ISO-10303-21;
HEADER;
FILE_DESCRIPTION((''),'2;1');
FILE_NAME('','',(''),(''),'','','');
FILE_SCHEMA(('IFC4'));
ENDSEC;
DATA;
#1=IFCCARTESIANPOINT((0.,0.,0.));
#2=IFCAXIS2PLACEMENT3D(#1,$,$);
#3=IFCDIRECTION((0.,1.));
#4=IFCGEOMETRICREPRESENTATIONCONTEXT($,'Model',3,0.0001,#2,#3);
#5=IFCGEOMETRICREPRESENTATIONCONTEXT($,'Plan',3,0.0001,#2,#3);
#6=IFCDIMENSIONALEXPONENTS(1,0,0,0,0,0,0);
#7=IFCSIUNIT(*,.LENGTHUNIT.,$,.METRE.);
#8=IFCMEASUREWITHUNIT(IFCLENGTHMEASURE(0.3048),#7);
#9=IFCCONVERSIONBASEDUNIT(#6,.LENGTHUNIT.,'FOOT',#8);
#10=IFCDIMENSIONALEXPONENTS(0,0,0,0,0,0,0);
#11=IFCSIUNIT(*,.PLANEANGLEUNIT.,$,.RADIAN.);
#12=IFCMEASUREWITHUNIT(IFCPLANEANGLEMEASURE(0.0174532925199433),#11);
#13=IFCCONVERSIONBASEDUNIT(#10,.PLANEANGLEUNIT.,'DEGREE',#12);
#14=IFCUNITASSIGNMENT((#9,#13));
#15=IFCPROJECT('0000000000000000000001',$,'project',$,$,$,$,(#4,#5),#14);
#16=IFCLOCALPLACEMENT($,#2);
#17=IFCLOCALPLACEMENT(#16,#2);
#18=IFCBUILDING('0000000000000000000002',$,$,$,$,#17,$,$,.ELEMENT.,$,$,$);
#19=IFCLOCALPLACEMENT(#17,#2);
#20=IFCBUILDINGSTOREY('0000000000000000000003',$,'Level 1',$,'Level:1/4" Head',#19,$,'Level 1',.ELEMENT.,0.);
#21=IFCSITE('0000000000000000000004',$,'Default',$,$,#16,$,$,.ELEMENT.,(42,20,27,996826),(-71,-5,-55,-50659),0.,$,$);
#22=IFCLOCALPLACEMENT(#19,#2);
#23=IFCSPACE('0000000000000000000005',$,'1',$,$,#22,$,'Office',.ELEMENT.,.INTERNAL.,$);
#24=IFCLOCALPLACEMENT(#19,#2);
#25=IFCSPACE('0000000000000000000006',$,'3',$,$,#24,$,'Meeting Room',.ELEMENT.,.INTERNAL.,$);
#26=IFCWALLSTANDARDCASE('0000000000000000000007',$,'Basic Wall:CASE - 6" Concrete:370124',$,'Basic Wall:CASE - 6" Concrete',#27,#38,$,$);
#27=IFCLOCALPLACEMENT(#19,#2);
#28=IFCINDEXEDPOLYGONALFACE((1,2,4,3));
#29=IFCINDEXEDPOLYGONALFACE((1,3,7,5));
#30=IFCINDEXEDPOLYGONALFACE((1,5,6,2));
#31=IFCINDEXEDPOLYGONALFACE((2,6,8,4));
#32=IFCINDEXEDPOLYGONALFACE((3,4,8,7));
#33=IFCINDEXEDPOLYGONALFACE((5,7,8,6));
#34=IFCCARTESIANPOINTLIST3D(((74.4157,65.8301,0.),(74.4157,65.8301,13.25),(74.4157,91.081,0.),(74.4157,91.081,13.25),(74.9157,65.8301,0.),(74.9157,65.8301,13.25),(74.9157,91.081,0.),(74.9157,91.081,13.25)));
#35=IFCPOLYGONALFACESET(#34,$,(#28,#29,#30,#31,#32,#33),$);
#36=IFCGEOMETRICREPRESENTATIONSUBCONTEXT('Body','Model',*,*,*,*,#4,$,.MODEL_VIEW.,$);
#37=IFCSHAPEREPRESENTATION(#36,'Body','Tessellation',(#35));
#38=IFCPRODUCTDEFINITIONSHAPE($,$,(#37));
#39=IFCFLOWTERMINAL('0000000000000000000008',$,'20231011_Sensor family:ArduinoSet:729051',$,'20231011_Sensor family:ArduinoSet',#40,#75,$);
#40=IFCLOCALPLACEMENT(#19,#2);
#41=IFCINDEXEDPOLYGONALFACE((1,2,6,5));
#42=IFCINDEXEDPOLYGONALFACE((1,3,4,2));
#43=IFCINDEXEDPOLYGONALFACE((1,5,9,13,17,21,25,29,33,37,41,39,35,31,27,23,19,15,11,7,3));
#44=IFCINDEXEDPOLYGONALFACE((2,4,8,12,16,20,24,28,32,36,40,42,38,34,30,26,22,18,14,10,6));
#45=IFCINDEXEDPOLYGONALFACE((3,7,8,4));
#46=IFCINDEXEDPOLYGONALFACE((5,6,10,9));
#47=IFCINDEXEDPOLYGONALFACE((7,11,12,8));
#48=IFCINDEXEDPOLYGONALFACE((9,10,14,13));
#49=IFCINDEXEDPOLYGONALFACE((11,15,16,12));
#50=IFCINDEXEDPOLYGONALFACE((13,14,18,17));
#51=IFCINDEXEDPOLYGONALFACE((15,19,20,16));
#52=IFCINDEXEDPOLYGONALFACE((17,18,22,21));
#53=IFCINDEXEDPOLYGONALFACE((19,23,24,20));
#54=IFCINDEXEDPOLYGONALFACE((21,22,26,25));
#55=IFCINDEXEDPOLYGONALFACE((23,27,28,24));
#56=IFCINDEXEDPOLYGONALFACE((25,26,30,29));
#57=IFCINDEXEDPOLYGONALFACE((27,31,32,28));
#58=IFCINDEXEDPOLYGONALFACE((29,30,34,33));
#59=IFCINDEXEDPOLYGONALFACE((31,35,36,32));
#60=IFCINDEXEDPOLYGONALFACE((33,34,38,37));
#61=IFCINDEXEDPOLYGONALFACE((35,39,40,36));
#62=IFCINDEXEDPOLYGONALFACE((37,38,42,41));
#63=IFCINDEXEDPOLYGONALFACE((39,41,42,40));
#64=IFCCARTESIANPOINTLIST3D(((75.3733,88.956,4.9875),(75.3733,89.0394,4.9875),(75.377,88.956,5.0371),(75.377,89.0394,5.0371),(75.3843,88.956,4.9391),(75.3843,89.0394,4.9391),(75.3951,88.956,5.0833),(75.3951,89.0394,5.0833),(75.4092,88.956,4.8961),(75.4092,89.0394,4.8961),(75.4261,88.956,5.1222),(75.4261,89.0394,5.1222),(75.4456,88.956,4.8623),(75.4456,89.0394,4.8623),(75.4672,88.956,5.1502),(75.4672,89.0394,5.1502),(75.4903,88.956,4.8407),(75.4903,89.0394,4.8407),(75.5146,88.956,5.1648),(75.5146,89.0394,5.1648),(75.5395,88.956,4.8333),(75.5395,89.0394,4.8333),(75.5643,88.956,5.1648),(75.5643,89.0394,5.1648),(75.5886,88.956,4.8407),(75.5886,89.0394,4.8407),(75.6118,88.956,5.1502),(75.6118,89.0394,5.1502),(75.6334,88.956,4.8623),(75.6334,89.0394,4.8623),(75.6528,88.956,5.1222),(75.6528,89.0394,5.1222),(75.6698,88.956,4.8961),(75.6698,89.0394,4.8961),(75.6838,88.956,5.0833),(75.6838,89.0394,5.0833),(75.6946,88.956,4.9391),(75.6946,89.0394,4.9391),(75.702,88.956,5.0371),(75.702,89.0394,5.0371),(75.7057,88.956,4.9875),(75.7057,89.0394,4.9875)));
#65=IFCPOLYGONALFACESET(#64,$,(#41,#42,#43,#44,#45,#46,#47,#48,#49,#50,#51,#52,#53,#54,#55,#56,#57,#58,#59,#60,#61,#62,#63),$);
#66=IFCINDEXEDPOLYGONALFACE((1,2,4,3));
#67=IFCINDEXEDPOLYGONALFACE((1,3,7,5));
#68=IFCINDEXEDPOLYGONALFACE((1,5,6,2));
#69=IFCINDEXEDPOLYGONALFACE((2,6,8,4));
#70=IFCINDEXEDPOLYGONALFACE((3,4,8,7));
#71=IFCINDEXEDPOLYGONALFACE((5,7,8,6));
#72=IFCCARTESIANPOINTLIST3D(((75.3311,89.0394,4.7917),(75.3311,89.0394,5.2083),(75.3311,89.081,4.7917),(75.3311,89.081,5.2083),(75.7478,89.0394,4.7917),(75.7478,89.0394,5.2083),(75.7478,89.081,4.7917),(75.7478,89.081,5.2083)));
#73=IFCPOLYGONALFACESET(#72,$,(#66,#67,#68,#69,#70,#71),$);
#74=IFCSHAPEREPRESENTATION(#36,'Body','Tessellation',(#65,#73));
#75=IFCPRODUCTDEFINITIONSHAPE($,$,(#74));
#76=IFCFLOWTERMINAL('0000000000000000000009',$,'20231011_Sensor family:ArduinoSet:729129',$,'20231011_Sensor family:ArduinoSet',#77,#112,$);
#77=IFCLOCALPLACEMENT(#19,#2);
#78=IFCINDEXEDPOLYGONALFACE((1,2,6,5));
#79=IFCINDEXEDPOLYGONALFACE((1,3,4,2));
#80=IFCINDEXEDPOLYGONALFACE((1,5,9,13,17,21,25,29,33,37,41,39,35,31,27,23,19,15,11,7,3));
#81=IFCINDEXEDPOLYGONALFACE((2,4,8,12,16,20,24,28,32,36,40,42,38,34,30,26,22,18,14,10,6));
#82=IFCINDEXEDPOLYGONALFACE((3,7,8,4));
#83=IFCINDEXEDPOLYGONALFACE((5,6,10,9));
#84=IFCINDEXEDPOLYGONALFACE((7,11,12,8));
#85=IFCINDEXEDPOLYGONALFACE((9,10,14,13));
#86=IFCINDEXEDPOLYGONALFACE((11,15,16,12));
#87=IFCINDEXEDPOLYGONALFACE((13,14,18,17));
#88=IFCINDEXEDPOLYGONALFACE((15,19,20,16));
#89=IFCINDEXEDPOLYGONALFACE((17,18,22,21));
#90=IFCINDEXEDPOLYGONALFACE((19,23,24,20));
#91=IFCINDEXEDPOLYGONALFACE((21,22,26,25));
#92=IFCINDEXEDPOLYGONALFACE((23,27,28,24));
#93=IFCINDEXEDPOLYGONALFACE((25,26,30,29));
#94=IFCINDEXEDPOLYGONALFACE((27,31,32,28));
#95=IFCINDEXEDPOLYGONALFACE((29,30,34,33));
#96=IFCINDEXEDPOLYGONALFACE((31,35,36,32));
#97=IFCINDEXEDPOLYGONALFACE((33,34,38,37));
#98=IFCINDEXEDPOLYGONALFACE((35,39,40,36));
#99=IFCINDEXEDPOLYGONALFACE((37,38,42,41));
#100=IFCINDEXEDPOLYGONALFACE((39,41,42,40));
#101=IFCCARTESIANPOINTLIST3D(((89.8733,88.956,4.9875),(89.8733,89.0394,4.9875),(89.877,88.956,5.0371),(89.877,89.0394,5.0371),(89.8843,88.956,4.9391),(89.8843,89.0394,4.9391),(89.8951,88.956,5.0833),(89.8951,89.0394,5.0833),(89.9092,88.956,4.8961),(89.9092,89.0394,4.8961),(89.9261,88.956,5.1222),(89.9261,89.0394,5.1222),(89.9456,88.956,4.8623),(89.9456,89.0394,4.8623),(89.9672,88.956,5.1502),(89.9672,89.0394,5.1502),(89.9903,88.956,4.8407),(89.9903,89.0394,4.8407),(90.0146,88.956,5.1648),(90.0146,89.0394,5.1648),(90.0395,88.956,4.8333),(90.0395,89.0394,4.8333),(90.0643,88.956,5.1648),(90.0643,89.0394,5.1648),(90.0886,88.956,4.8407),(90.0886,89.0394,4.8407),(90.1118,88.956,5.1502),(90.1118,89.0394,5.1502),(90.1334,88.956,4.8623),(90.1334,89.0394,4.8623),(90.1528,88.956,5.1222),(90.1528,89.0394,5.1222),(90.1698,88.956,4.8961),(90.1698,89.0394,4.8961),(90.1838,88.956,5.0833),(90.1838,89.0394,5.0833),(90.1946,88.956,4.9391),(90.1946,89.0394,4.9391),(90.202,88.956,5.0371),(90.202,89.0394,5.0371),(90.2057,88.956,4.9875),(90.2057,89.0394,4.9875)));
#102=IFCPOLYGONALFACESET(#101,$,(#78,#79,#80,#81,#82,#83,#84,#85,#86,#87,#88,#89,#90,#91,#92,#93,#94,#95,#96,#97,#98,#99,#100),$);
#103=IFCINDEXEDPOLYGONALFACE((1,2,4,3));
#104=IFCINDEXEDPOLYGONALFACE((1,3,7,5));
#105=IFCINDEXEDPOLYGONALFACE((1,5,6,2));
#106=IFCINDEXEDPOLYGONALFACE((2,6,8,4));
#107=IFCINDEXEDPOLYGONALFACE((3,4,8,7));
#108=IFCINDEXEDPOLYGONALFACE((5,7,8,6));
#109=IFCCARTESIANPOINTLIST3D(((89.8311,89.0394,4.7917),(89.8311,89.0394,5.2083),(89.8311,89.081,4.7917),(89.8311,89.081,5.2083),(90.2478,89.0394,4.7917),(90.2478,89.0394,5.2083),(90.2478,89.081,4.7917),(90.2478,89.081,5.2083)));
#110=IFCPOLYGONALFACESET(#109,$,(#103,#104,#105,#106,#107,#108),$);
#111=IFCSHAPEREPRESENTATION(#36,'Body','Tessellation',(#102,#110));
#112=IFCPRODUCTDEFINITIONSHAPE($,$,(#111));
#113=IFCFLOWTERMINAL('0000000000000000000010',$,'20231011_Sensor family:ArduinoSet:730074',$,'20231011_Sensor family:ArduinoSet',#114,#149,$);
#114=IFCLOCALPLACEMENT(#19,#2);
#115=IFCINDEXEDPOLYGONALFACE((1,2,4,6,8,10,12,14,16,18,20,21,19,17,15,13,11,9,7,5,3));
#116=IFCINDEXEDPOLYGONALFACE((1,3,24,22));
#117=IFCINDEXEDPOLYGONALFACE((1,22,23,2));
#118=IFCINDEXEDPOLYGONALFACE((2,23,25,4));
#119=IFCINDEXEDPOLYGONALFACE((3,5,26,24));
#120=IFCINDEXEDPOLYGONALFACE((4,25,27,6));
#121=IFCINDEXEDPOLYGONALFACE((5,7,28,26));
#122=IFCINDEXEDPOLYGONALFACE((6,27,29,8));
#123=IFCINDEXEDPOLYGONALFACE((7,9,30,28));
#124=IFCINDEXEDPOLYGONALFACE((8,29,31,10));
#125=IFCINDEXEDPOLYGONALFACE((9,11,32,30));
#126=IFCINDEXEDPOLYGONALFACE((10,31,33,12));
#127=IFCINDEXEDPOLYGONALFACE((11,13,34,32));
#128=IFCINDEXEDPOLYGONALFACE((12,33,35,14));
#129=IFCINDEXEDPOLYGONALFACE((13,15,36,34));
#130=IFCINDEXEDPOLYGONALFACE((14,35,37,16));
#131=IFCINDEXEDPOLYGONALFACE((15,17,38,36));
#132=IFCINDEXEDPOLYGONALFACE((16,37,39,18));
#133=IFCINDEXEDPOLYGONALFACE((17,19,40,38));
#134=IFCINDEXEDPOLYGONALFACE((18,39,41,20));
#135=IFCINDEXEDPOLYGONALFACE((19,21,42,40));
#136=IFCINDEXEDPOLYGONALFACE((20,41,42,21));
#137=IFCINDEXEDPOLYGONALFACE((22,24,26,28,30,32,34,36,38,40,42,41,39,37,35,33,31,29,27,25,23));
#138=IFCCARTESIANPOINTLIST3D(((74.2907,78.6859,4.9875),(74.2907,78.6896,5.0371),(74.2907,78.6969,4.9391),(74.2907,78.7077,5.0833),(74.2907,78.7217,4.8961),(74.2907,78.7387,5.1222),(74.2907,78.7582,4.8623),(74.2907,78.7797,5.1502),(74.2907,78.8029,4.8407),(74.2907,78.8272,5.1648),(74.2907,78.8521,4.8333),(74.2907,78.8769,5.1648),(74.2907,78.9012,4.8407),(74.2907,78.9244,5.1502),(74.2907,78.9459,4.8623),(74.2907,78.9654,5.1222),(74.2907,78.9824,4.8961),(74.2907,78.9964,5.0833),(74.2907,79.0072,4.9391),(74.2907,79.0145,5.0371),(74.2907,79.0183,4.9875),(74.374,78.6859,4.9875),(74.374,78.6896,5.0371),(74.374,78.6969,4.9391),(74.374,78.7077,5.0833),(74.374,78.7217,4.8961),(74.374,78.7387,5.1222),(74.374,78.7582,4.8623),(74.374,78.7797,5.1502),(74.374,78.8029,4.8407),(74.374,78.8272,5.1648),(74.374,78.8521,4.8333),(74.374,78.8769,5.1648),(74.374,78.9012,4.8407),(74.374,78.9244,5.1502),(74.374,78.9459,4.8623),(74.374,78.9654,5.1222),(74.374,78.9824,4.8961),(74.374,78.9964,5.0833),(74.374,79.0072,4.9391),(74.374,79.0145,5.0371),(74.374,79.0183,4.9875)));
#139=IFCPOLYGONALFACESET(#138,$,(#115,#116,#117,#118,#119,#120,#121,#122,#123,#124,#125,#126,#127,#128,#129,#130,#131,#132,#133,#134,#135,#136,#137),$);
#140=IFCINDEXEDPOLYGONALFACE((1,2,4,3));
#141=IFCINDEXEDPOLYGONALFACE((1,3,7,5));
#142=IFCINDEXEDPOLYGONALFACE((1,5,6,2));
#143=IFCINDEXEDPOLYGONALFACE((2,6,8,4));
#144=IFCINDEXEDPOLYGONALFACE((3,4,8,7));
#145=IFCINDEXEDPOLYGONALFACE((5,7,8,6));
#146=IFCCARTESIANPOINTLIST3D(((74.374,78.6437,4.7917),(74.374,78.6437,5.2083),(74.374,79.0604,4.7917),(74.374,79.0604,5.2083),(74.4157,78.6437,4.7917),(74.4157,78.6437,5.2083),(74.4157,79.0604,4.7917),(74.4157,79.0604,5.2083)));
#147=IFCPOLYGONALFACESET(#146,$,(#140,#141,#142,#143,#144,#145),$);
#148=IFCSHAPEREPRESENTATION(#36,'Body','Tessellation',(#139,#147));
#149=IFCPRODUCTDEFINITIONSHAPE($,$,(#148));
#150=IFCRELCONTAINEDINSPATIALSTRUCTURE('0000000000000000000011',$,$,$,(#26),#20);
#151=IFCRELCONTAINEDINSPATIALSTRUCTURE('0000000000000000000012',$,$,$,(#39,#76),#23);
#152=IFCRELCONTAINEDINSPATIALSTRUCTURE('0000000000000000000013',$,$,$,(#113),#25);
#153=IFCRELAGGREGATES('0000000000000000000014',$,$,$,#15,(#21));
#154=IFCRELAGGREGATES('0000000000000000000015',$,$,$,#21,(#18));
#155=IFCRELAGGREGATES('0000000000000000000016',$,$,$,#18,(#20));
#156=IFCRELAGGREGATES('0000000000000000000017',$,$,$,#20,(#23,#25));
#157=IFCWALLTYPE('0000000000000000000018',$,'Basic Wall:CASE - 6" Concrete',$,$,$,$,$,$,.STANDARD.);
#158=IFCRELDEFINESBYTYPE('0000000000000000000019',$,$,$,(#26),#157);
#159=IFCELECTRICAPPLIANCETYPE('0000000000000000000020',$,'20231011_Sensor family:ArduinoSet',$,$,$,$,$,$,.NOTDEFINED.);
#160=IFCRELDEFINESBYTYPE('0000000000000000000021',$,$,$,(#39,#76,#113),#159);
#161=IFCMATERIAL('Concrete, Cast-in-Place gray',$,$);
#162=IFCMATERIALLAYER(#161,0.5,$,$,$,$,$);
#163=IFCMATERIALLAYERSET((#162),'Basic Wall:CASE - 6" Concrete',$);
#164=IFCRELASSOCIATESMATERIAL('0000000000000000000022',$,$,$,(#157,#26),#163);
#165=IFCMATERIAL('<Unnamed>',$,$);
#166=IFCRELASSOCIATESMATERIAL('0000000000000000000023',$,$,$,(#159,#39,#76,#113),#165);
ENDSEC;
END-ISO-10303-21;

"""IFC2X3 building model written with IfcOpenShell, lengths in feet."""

from ifc_helpers import new_model, entity, si_unit, converted_unit, direction, frame, frame_2d, origin, origin_2d_with_axis, place, context, subcontext, project, spatial, rectangle, circle, extrude, source, transform, mapped, material, layer, layer_set, layer_usage, type_object, type_shapes, element, save


model = new_model("IFC2X3")

# Units and contexts
model_context = context("Model", 3, precision=0.0001, world=origin(), true_north=direction((0.0, 1.0)))
plan_context = context("Plan", 3, precision=0.0001, world=origin(), true_north=direction((0.0, 1.0)))
body_context = subcontext(model_context, "Body", "Model", "MODEL_VIEW")
ifc_project = project(units=[converted_unit("LENGTHUNIT", "FOOT", entity("IfcLengthMeasure", 0.3048), si_unit("LENGTHUNIT", "METRE"), dimensions=[1, 0, 0, 0, 0, 0, 0]), converted_unit("PLANEANGLEUNIT", "DEGREE", entity("IfcPlaneAngleMeasure", 0.0174532925199433), si_unit("PLANEANGLEUNIT", "RADIAN"), dimensions=[0, 0, 0, 0, 0, 0, 0])], contexts=[model_context, plan_context])

# Site, building, storey
site_placement = place(None, origin())
site = spatial("IfcSite", under=ifc_project, at=site_placement, Name="Default", CompositionType="ELEMENT", RefLatitude=(42, 20, 27, 996826), RefLongitude=(-71, -5, -55, -50659), RefElevation=0.0)
building_placement = place(site_placement, origin())
building = spatial("IfcBuilding", under=site, at=building_placement, CompositionType="ELEMENT")
storey_placement = place(building_placement, origin())
storey = spatial("IfcBuildingStorey", under=building, at=storey_placement, Name="Level 1", ObjectType="Level:1/4\" Head", LongName="Level 1", CompositionType="ELEMENT", Elevation=0.0)

# Wall
ifc_material_1 = material(Name="Concrete, Cast-in-Place gray")
ifc_layer = layer(ifc_material_1, 0.5)
ifc_layer_set = layer_set([ifc_layer], Name="Basic Wall:CASE - 6\" Concrete")
ifc_layer_usage = layer_usage(ifc_layer_set, "AXIS2", "NEGATIVE", 0.25)
wall_type = type_object("IfcWallType", Name="Basic Wall:CASE - 6\" Concrete", PredefinedType="STANDARD", material=ifc_layer_set)
wall_placement = place(storey_placement, frame((74.6657, 91.081, 0.0), z_axis=(0.0, 0.0, 1.0), x_axis=(0.0, -1.0, 0.0)))
element("IfcWallStandardCase", 1, at=wall_placement, inside=storey, type_object=wall_type, material=ifc_layer_usage, Name="Basic Wall:CASE - 6\" Concrete:370124", ObjectType="Basic Wall:CASE - 6\" Concrete", context=body_context, shape_type="SweptSolid", body=[
    extrude(rectangle(XDim=25.2509, YDim=0.5, at=frame_2d((12.6254, 0.0), x_axis=(-1.0, 0.0))), origin(), (0.0, 0.0, 1.0), 13.25),
])

# Shared definitions
space_1_placement = place(storey_placement, origin())
space_1 = spatial("IfcSpace", under=storey, at=space_1_placement, Name="1", LongName="Office", CompositionType="ELEMENT", InteriorOrExteriorSpace="INTERNAL")

# Flow terminals
ifc_material_2 = material(Name="<Unnamed>")
electric_appliance_type = type_object("IfcElectricApplianceType", Name="20231011_Sensor family:ArduinoSet", PredefinedType="NOTDEFINED", material=ifc_material_2)
shared_shape_1 = source(origin(), body_context, "Body", "SweptSolid", [
    extrude(circle(Radius=0.1667, at=frame_2d((0.0, 0.0), x_axis=(1.0, 0.0))), frame((0.0417, 0.0, 0.0), z_axis=(1.0, 0.0, 0.0), x_axis=(0.0, 0.0, -1.0)), (0.0, 0.0, 1.0), 0.0833),
    extrude(rectangle(XDim=0.0417, YDim=0.4167, at=origin_2d_with_axis()), frame((0.0208, 0.0, -0.2083), z_axis=(0.0, 0.0, 1.0), x_axis=(-1.0, 0.0, 0.0)), (0.0, 0.0, 1.0), 0.4167),
])
type_shapes(electric_appliance_type, [shared_shape_1])
for number, where, z_axis, x_axis, name in (
    (2, (75.5395, 89.081, 5.0), (0.0, 0.0, 1.0), (0.0, -1.0, 0.0), "20231011_Sensor family:ArduinoSet:729051"),
    (3, (90.0395, 89.081, 5.0), (0.0, 0.0, 1.0), (0.0, -1.0, 0.0), "20231011_Sensor family:ArduinoSet:729129"),
):
    element("IfcFlowTerminal", number, at=place(space_1_placement, frame(where, z_axis=z_axis, x_axis=x_axis)), inside=space_1, type_object=electric_appliance_type, material=ifc_material_2, Name=name, ObjectType="20231011_Sensor family:ArduinoSet", context=body_context, shape_type="MappedRepresentation", body=[
        mapped(shared_shape_1, transform((0.0, 0.0, 0.0), scale=1.0)),
    ])

# Shared definitions
space_2_placement = place(storey_placement, origin())
space_2 = spatial("IfcSpace", under=storey, at=space_2_placement, Name="3", LongName="Meeting Room", CompositionType="ELEMENT", InteriorOrExteriorSpace="INTERNAL")

# Flow terminal
flow_terminal_placement = place(space_2_placement, frame((74.4157, 78.8521, 5.0), z_axis=(0.0, 0.0, 1.0), x_axis=(-1.0, 0.0, 0.0)))
element("IfcFlowTerminal", 4, at=flow_terminal_placement, inside=space_2, type_object=electric_appliance_type, material=ifc_material_2, Name="20231011_Sensor family:ArduinoSet:730074", ObjectType="20231011_Sensor family:ArduinoSet", context=body_context, shape_type="MappedRepresentation", body=[
    mapped(shared_shape_1, transform((0.0, 0.0, 0.0), scale=1.0)),
])

save(model, "model.ifc")
